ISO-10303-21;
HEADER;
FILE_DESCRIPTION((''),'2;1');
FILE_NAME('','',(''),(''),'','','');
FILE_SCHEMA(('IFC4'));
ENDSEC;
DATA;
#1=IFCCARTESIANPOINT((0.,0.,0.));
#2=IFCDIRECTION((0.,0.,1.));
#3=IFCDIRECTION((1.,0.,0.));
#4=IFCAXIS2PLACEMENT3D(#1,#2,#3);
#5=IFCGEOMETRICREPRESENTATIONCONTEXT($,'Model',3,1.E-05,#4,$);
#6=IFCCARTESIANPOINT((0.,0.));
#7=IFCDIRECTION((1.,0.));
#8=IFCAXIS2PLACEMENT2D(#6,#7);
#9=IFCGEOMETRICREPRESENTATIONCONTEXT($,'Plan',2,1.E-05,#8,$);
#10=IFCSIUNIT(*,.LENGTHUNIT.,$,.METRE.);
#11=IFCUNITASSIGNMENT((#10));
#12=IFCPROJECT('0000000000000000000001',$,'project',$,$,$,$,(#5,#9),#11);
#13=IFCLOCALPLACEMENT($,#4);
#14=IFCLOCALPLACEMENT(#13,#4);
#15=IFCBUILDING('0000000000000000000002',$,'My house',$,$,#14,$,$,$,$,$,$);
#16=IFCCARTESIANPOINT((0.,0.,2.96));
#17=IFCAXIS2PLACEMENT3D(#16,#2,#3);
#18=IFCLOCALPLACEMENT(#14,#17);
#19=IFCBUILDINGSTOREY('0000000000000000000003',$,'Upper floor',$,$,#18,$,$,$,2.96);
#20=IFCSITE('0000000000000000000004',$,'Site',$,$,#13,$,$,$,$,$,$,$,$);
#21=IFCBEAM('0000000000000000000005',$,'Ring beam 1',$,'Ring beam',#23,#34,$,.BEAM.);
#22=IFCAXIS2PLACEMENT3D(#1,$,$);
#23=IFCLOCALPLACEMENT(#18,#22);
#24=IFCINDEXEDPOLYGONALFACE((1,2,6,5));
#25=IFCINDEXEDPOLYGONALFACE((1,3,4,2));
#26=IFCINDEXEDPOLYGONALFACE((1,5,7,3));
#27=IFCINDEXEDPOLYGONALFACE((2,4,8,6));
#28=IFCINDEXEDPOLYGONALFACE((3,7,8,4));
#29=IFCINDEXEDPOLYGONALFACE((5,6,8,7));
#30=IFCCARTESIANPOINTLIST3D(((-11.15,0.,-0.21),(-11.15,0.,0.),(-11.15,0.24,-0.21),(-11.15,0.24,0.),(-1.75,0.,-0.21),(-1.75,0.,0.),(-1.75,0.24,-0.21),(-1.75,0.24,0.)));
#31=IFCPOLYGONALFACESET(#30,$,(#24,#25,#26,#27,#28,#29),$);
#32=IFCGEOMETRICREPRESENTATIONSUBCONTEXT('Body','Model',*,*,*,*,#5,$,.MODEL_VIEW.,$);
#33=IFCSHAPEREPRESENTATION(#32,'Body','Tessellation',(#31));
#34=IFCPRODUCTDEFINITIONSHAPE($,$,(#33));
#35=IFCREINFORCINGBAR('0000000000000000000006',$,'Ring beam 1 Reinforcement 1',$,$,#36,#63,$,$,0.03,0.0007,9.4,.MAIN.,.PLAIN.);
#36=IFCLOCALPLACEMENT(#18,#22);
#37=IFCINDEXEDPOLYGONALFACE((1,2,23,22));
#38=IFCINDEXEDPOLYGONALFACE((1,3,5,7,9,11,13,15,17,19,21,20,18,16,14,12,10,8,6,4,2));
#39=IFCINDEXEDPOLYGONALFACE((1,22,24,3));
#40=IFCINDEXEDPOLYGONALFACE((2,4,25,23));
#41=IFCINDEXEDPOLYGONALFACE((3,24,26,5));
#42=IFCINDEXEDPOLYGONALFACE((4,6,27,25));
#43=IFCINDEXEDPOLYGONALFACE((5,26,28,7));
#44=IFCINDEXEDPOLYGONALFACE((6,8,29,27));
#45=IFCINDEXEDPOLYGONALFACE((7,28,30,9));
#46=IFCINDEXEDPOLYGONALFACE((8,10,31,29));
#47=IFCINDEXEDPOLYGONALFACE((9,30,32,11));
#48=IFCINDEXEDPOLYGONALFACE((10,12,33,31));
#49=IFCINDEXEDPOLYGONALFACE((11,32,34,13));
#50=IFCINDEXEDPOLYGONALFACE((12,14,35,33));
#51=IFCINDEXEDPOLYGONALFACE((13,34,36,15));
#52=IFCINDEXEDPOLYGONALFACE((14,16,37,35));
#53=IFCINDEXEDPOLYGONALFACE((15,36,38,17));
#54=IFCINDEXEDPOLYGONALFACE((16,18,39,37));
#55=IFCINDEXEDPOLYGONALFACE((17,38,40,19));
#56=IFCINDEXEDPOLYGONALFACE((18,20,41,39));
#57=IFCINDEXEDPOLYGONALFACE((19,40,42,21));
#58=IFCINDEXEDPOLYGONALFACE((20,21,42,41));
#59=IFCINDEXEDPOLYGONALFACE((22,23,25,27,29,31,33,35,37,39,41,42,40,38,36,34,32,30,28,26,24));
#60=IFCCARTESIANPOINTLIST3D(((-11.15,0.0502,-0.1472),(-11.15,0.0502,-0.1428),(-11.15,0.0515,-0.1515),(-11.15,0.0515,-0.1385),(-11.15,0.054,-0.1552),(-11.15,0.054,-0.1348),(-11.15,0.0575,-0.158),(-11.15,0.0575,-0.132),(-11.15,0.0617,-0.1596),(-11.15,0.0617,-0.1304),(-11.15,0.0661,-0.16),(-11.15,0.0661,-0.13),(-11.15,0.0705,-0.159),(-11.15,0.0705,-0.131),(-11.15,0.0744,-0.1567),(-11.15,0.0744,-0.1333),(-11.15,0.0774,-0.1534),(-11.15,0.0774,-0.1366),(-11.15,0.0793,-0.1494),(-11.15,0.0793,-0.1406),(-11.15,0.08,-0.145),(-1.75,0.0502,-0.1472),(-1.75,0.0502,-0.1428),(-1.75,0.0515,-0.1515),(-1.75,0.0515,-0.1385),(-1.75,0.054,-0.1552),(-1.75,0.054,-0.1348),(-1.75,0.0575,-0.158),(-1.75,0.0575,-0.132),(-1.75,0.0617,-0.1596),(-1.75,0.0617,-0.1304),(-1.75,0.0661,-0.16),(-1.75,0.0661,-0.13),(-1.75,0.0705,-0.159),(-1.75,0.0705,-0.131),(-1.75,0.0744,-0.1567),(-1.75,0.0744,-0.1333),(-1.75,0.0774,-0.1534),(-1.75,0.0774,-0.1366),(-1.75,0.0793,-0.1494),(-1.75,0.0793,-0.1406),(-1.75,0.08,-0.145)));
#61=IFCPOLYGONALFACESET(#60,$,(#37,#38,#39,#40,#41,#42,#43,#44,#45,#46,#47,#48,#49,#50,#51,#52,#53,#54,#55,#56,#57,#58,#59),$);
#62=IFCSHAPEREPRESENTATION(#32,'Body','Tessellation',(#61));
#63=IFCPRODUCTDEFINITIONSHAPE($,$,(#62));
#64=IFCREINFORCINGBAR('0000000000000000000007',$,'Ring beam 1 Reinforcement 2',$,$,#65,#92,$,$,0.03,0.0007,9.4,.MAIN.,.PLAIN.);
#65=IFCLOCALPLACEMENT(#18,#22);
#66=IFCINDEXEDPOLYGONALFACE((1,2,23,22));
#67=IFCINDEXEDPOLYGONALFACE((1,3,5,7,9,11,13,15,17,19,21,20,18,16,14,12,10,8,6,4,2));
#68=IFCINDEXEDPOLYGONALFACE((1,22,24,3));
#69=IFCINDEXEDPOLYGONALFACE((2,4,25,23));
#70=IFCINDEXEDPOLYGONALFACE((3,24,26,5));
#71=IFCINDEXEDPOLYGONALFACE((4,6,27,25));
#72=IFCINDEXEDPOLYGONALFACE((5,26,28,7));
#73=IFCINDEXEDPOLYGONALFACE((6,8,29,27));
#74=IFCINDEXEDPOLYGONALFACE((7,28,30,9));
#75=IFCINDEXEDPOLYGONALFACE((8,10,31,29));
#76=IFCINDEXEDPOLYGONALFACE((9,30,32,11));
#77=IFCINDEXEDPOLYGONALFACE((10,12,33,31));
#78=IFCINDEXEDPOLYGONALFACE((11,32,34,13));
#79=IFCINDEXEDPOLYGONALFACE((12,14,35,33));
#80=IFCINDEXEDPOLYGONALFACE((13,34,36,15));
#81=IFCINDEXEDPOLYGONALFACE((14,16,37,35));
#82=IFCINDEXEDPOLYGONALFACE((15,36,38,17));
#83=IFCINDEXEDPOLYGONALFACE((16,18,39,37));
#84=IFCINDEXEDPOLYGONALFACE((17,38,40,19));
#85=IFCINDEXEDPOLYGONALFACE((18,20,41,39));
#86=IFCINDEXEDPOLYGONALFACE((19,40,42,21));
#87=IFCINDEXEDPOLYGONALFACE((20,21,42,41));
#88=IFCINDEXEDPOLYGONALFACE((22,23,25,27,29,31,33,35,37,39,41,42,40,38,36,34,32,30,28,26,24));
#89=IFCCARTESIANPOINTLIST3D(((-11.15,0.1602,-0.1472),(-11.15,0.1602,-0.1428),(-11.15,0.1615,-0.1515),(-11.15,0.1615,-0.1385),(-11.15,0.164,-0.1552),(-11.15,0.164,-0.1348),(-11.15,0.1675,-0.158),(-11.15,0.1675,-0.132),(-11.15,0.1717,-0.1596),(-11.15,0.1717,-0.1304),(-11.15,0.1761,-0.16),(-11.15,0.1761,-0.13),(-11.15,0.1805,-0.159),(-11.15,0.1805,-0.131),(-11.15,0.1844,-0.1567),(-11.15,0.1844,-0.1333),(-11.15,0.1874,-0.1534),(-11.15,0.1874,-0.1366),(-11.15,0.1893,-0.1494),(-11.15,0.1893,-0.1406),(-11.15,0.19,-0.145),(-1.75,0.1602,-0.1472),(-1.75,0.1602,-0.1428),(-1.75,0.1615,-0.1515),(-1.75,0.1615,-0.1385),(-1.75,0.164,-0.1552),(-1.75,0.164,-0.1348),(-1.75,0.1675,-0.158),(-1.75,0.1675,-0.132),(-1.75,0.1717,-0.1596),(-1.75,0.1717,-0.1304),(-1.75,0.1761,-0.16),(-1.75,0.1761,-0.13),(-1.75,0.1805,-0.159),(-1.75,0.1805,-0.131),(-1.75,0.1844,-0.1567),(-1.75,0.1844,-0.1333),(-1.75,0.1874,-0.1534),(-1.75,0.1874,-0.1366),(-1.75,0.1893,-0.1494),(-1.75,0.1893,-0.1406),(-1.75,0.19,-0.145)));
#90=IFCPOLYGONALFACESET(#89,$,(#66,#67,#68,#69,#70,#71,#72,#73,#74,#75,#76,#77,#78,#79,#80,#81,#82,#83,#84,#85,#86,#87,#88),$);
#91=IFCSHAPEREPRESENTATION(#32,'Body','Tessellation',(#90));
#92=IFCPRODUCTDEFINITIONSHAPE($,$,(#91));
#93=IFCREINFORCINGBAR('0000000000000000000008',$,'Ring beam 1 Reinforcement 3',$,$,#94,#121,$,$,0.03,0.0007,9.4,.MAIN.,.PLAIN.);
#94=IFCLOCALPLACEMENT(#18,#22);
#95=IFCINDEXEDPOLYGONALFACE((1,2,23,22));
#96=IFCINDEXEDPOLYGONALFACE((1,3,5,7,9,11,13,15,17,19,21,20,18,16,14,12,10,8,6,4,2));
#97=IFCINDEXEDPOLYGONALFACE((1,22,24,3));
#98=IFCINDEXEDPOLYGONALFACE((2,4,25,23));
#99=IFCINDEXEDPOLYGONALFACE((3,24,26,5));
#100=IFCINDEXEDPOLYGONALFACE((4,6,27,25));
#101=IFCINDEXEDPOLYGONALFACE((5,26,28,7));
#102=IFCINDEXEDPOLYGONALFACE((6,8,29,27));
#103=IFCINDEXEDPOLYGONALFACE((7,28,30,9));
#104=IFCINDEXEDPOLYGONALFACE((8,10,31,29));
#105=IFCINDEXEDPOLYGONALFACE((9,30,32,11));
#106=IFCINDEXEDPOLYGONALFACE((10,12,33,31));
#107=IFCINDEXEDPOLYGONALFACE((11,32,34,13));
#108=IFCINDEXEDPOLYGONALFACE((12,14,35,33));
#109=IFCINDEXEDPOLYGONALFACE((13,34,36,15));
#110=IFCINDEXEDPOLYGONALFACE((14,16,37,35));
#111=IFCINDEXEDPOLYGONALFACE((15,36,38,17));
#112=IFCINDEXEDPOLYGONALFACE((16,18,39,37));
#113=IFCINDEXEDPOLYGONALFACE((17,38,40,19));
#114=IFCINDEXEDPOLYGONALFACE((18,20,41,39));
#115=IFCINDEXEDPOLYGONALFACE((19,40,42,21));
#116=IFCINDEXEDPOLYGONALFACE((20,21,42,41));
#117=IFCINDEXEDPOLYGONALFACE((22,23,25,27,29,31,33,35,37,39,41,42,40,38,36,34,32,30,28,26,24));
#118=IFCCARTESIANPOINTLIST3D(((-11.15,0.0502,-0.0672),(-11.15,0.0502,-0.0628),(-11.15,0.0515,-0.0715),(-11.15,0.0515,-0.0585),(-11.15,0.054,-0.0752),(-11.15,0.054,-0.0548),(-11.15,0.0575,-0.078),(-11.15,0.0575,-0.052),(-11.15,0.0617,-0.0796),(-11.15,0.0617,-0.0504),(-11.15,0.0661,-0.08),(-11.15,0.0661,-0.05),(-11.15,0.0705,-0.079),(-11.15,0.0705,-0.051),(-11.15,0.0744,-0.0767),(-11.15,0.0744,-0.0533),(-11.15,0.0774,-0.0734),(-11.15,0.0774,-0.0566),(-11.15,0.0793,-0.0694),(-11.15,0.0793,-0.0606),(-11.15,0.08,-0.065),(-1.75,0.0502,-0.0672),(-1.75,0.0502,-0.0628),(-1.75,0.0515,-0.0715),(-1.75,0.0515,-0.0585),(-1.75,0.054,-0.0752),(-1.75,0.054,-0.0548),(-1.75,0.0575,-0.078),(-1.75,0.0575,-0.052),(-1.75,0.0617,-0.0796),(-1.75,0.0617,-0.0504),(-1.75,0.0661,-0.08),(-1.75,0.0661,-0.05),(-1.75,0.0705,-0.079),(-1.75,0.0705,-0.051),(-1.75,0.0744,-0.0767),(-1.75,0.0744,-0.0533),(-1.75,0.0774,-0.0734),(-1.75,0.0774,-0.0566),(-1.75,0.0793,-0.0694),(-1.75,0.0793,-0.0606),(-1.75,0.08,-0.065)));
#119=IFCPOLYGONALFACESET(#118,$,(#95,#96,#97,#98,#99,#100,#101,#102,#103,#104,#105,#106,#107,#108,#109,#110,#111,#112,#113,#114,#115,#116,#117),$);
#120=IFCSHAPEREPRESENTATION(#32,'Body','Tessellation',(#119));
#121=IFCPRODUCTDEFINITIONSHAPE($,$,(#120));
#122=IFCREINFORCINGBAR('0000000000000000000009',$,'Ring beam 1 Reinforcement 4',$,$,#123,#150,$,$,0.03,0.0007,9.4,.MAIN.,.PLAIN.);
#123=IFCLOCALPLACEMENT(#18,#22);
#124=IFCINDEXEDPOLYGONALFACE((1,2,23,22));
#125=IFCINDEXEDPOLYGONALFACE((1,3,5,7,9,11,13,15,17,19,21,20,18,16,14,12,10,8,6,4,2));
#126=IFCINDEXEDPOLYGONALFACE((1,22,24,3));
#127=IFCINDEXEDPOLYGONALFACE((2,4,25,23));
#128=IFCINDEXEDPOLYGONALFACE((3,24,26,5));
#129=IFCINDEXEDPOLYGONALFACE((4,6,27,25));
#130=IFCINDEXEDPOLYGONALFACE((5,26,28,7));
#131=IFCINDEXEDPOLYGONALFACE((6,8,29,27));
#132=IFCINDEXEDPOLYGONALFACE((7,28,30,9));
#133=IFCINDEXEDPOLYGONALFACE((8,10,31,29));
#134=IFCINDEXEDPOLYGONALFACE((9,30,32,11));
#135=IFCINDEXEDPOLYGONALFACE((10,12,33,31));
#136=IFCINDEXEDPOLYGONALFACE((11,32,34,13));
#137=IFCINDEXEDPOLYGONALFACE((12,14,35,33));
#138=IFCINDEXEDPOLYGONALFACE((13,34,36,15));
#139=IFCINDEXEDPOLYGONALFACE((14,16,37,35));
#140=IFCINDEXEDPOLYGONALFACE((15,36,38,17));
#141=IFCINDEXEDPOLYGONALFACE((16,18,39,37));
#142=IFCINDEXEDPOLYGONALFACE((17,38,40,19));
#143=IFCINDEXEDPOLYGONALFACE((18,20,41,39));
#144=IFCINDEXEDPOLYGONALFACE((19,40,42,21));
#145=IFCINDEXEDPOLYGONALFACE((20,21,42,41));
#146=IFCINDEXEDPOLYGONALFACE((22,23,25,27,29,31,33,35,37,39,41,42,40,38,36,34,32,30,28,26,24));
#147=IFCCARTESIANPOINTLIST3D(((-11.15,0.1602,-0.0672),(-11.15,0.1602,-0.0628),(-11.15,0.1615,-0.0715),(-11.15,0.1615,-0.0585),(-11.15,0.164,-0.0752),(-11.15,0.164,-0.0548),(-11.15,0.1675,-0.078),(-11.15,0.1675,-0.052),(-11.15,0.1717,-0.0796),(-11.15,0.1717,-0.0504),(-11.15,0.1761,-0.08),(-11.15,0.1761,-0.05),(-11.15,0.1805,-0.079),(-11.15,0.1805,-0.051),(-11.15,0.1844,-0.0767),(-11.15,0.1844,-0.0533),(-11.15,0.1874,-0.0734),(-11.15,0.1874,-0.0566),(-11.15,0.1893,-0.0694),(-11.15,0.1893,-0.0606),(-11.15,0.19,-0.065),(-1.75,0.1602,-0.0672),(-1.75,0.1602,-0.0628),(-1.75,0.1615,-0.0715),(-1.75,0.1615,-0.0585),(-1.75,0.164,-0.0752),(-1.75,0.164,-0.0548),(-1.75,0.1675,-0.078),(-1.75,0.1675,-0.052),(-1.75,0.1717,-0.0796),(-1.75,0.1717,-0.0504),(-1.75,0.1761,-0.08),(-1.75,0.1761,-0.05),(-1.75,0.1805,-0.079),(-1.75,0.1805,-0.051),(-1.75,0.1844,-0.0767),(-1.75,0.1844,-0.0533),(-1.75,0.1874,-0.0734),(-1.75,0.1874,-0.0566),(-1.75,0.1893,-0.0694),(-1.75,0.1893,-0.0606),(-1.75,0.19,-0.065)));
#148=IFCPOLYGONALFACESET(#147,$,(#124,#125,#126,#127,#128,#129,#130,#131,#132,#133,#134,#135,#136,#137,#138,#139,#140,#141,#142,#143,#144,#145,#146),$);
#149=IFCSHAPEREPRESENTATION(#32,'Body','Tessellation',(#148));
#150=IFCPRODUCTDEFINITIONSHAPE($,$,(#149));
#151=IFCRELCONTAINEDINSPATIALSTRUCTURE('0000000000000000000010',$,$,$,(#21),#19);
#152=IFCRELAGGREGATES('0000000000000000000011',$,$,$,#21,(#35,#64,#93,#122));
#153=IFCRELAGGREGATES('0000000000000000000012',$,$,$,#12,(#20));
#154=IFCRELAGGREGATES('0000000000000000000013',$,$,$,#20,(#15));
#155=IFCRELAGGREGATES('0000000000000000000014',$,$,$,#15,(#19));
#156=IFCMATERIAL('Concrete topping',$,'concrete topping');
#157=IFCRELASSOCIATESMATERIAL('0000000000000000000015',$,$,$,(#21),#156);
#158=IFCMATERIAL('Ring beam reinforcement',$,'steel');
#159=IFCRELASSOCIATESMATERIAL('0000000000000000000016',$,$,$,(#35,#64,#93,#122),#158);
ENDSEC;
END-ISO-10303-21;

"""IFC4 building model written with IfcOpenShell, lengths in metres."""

from ifc_helpers import new_model, si_unit, frame, origin_with_axes, origin_2d, origin_2d_with_axis, place, context, subcontext, project, spatial, circle_curve, rectangle, outline, extrude, source, transform, mapped, material, element, aggregate, save


model = new_model("IFC4")

# Units and contexts
model_context = context("Model", 3, precision=1e-05, world=origin_with_axes())
plan_context = context("Plan", 2, precision=1e-05, world=origin_2d_with_axis())
body_context = subcontext(model_context, "Body", "Model", "MODEL_VIEW")
ifc_project = project(units=[si_unit("LENGTHUNIT", "METRE")], contexts=[model_context, plan_context])

# Site, building, storey
site_placement = place(None, origin_with_axes())
site = spatial("IfcSite", under=ifc_project, at=site_placement, Name="Site")
building_placement = place(site_placement, origin_with_axes())
building = spatial("IfcBuilding", under=site, at=building_placement, Name="My house")
storey_placement = place(building_placement, frame((0.0, 0.0, 2.96), z_axis=(0.0, 0.0, 1.0), x_axis=(1.0, 0.0, 0.0)))
storey = spatial("IfcBuildingStorey", under=building, at=storey_placement, Name="Upper floor", Elevation=2.96)

# Beam
ifc_material_1 = material(Name="Concrete topping", Category="concrete topping")
shared_shape_1 = source(origin_with_axes(), body_context, "Body", "SweptSolid", [
    extrude(rectangle(XDim=0.24, YDim=0.21), frame((0.0, 0.0, 0.0), z_axis=(1.0, 0.0, 0.0), x_axis=(0.0, 1.0, 0.0)), (0.0, 0.0, 1.0), 9.4),
])
beam_1_placement = place(storey_placement, frame((-1.75, 0.12, -0.105), z_axis=(0.0, 0.0, 1.0), x_axis=(1.0, 0.0, 0.0)))
beam_1 = element("IfcBeam", 1, at=beam_1_placement, inside=storey, material=ifc_material_1, Name="Ring beam 1", ObjectType="Ring beam", PredefinedType="BEAM", context=body_context, shape_type="MappedRepresentation", body=[
    mapped(shared_shape_1, transform((0.0, 0.0, 0.0), x_axis=(-1.0, 0.0, 0.0), y_axis=(0.0, 1.0, 0.0), z_axis=(0.0, 0.0, 1.0), scale=1.0)),
])

# Reinforcing bars
ifc_material_2 = material(Name="Ring beam reinforcement", Category="steel")
shared_shape_2 = source(origin_with_axes(), body_context, "Body", "SweptSolid", [
    extrude(outline(circle_curve(origin_2d(), 0.015)), frame((0.0, 0.0, 0.0), z_axis=(1.0, 0.0, 0.0), x_axis=(0.0, 1.0, 0.0)), (0.0, 0.0, 1.0), 9.4),
])
reinforcing_bar_1_placement = place(beam_1_placement, frame((0.0, -0.055, -0.04), z_axis=(0.0, 0.0, 1.0), x_axis=(1.0, 0.0, 0.0)))
reinforcing_bar_1 = element("IfcReinforcingBar", 2, at=reinforcing_bar_1_placement, material=ifc_material_2, Name="Ring beam 1 Reinforcement 1", BarLength=9.4, BarSurface="PLAIN", CrossSectionArea=0.0007, NominalDiameter=0.03, PredefinedType="MAIN", context=body_context, shape_type="MappedRepresentation", body=[
    mapped(shared_shape_2, transform((0.0, 0.0, 0.0), x_axis=(-1.0, 0.0, 0.0), y_axis=(0.0, 1.0, 0.0), z_axis=(0.0, 0.0, 1.0), scale=1.0)),
])
shared_shape_3 = source(origin_with_axes(), body_context, "Body", "SweptSolid", [
    extrude(outline(circle_curve(origin_2d(), 0.015)), frame((0.0, 0.0, 0.0), z_axis=(1.0, 0.0, 0.0), x_axis=(0.0, 1.0, 0.0)), (0.0, 0.0, 1.0), 9.4),
])
reinforcing_bar_2_placement = place(beam_1_placement, frame((0.0, 0.055, -0.04), z_axis=(0.0, 0.0, 1.0), x_axis=(1.0, 0.0, 0.0)))
reinforcing_bar_2 = element("IfcReinforcingBar", 3, at=reinforcing_bar_2_placement, material=ifc_material_2, Name="Ring beam 1 Reinforcement 2", BarLength=9.4, BarSurface="PLAIN", CrossSectionArea=0.0007, NominalDiameter=0.03, PredefinedType="MAIN", context=body_context, shape_type="MappedRepresentation", body=[
    mapped(shared_shape_3, transform((0.0, 0.0, 0.0), x_axis=(-1.0, 0.0, 0.0), y_axis=(0.0, 1.0, 0.0), z_axis=(0.0, 0.0, 1.0), scale=1.0)),
])
shared_shape_4 = source(origin_with_axes(), body_context, "Body", "SweptSolid", [
    extrude(outline(circle_curve(origin_2d(), 0.015)), frame((0.0, 0.0, 0.0), z_axis=(1.0, 0.0, 0.0), x_axis=(0.0, 1.0, 0.0)), (0.0, 0.0, 1.0), 9.4),
])
reinforcing_bar_3_placement = place(beam_1_placement, frame((0.0, -0.055, 0.04), z_axis=(0.0, 0.0, 1.0), x_axis=(1.0, 0.0, 0.0)))
reinforcing_bar_3 = element("IfcReinforcingBar", 4, at=reinforcing_bar_3_placement, material=ifc_material_2, Name="Ring beam 1 Reinforcement 3", BarLength=9.4, BarSurface="PLAIN", CrossSectionArea=0.0007, NominalDiameter=0.03, PredefinedType="MAIN", context=body_context, shape_type="MappedRepresentation", body=[
    mapped(shared_shape_4, transform((0.0, 0.0, 0.0), x_axis=(-1.0, 0.0, 0.0), y_axis=(0.0, 1.0, 0.0), z_axis=(0.0, 0.0, 1.0), scale=1.0)),
])
shared_shape_5 = source(origin_with_axes(), body_context, "Body", "SweptSolid", [
    extrude(outline(circle_curve(origin_2d(), 0.015)), frame((0.0, 0.0, 0.0), z_axis=(1.0, 0.0, 0.0), x_axis=(0.0, 1.0, 0.0)), (0.0, 0.0, 1.0), 9.4),
])
reinforcing_bar_4_placement = place(beam_1_placement, frame((0.0, 0.055, 0.04), z_axis=(0.0, 0.0, 1.0), x_axis=(1.0, 0.0, 0.0)))
reinforcing_bar_4 = element("IfcReinforcingBar", 5, at=reinforcing_bar_4_placement, material=ifc_material_2, Name="Ring beam 1 Reinforcement 4", BarLength=9.4, BarSurface="PLAIN", CrossSectionArea=0.0007, NominalDiameter=0.03, PredefinedType="MAIN", context=body_context, shape_type="MappedRepresentation", body=[
    mapped(shared_shape_5, transform((0.0, 0.0, 0.0), x_axis=(-1.0, 0.0, 0.0), y_axis=(0.0, 1.0, 0.0), z_axis=(0.0, 0.0, 1.0), scale=1.0)),
])
aggregate(beam_1, [reinforcing_bar_1, reinforcing_bar_2, reinforcing_bar_3, reinforcing_bar_4])

save(model, "model.ifc")
